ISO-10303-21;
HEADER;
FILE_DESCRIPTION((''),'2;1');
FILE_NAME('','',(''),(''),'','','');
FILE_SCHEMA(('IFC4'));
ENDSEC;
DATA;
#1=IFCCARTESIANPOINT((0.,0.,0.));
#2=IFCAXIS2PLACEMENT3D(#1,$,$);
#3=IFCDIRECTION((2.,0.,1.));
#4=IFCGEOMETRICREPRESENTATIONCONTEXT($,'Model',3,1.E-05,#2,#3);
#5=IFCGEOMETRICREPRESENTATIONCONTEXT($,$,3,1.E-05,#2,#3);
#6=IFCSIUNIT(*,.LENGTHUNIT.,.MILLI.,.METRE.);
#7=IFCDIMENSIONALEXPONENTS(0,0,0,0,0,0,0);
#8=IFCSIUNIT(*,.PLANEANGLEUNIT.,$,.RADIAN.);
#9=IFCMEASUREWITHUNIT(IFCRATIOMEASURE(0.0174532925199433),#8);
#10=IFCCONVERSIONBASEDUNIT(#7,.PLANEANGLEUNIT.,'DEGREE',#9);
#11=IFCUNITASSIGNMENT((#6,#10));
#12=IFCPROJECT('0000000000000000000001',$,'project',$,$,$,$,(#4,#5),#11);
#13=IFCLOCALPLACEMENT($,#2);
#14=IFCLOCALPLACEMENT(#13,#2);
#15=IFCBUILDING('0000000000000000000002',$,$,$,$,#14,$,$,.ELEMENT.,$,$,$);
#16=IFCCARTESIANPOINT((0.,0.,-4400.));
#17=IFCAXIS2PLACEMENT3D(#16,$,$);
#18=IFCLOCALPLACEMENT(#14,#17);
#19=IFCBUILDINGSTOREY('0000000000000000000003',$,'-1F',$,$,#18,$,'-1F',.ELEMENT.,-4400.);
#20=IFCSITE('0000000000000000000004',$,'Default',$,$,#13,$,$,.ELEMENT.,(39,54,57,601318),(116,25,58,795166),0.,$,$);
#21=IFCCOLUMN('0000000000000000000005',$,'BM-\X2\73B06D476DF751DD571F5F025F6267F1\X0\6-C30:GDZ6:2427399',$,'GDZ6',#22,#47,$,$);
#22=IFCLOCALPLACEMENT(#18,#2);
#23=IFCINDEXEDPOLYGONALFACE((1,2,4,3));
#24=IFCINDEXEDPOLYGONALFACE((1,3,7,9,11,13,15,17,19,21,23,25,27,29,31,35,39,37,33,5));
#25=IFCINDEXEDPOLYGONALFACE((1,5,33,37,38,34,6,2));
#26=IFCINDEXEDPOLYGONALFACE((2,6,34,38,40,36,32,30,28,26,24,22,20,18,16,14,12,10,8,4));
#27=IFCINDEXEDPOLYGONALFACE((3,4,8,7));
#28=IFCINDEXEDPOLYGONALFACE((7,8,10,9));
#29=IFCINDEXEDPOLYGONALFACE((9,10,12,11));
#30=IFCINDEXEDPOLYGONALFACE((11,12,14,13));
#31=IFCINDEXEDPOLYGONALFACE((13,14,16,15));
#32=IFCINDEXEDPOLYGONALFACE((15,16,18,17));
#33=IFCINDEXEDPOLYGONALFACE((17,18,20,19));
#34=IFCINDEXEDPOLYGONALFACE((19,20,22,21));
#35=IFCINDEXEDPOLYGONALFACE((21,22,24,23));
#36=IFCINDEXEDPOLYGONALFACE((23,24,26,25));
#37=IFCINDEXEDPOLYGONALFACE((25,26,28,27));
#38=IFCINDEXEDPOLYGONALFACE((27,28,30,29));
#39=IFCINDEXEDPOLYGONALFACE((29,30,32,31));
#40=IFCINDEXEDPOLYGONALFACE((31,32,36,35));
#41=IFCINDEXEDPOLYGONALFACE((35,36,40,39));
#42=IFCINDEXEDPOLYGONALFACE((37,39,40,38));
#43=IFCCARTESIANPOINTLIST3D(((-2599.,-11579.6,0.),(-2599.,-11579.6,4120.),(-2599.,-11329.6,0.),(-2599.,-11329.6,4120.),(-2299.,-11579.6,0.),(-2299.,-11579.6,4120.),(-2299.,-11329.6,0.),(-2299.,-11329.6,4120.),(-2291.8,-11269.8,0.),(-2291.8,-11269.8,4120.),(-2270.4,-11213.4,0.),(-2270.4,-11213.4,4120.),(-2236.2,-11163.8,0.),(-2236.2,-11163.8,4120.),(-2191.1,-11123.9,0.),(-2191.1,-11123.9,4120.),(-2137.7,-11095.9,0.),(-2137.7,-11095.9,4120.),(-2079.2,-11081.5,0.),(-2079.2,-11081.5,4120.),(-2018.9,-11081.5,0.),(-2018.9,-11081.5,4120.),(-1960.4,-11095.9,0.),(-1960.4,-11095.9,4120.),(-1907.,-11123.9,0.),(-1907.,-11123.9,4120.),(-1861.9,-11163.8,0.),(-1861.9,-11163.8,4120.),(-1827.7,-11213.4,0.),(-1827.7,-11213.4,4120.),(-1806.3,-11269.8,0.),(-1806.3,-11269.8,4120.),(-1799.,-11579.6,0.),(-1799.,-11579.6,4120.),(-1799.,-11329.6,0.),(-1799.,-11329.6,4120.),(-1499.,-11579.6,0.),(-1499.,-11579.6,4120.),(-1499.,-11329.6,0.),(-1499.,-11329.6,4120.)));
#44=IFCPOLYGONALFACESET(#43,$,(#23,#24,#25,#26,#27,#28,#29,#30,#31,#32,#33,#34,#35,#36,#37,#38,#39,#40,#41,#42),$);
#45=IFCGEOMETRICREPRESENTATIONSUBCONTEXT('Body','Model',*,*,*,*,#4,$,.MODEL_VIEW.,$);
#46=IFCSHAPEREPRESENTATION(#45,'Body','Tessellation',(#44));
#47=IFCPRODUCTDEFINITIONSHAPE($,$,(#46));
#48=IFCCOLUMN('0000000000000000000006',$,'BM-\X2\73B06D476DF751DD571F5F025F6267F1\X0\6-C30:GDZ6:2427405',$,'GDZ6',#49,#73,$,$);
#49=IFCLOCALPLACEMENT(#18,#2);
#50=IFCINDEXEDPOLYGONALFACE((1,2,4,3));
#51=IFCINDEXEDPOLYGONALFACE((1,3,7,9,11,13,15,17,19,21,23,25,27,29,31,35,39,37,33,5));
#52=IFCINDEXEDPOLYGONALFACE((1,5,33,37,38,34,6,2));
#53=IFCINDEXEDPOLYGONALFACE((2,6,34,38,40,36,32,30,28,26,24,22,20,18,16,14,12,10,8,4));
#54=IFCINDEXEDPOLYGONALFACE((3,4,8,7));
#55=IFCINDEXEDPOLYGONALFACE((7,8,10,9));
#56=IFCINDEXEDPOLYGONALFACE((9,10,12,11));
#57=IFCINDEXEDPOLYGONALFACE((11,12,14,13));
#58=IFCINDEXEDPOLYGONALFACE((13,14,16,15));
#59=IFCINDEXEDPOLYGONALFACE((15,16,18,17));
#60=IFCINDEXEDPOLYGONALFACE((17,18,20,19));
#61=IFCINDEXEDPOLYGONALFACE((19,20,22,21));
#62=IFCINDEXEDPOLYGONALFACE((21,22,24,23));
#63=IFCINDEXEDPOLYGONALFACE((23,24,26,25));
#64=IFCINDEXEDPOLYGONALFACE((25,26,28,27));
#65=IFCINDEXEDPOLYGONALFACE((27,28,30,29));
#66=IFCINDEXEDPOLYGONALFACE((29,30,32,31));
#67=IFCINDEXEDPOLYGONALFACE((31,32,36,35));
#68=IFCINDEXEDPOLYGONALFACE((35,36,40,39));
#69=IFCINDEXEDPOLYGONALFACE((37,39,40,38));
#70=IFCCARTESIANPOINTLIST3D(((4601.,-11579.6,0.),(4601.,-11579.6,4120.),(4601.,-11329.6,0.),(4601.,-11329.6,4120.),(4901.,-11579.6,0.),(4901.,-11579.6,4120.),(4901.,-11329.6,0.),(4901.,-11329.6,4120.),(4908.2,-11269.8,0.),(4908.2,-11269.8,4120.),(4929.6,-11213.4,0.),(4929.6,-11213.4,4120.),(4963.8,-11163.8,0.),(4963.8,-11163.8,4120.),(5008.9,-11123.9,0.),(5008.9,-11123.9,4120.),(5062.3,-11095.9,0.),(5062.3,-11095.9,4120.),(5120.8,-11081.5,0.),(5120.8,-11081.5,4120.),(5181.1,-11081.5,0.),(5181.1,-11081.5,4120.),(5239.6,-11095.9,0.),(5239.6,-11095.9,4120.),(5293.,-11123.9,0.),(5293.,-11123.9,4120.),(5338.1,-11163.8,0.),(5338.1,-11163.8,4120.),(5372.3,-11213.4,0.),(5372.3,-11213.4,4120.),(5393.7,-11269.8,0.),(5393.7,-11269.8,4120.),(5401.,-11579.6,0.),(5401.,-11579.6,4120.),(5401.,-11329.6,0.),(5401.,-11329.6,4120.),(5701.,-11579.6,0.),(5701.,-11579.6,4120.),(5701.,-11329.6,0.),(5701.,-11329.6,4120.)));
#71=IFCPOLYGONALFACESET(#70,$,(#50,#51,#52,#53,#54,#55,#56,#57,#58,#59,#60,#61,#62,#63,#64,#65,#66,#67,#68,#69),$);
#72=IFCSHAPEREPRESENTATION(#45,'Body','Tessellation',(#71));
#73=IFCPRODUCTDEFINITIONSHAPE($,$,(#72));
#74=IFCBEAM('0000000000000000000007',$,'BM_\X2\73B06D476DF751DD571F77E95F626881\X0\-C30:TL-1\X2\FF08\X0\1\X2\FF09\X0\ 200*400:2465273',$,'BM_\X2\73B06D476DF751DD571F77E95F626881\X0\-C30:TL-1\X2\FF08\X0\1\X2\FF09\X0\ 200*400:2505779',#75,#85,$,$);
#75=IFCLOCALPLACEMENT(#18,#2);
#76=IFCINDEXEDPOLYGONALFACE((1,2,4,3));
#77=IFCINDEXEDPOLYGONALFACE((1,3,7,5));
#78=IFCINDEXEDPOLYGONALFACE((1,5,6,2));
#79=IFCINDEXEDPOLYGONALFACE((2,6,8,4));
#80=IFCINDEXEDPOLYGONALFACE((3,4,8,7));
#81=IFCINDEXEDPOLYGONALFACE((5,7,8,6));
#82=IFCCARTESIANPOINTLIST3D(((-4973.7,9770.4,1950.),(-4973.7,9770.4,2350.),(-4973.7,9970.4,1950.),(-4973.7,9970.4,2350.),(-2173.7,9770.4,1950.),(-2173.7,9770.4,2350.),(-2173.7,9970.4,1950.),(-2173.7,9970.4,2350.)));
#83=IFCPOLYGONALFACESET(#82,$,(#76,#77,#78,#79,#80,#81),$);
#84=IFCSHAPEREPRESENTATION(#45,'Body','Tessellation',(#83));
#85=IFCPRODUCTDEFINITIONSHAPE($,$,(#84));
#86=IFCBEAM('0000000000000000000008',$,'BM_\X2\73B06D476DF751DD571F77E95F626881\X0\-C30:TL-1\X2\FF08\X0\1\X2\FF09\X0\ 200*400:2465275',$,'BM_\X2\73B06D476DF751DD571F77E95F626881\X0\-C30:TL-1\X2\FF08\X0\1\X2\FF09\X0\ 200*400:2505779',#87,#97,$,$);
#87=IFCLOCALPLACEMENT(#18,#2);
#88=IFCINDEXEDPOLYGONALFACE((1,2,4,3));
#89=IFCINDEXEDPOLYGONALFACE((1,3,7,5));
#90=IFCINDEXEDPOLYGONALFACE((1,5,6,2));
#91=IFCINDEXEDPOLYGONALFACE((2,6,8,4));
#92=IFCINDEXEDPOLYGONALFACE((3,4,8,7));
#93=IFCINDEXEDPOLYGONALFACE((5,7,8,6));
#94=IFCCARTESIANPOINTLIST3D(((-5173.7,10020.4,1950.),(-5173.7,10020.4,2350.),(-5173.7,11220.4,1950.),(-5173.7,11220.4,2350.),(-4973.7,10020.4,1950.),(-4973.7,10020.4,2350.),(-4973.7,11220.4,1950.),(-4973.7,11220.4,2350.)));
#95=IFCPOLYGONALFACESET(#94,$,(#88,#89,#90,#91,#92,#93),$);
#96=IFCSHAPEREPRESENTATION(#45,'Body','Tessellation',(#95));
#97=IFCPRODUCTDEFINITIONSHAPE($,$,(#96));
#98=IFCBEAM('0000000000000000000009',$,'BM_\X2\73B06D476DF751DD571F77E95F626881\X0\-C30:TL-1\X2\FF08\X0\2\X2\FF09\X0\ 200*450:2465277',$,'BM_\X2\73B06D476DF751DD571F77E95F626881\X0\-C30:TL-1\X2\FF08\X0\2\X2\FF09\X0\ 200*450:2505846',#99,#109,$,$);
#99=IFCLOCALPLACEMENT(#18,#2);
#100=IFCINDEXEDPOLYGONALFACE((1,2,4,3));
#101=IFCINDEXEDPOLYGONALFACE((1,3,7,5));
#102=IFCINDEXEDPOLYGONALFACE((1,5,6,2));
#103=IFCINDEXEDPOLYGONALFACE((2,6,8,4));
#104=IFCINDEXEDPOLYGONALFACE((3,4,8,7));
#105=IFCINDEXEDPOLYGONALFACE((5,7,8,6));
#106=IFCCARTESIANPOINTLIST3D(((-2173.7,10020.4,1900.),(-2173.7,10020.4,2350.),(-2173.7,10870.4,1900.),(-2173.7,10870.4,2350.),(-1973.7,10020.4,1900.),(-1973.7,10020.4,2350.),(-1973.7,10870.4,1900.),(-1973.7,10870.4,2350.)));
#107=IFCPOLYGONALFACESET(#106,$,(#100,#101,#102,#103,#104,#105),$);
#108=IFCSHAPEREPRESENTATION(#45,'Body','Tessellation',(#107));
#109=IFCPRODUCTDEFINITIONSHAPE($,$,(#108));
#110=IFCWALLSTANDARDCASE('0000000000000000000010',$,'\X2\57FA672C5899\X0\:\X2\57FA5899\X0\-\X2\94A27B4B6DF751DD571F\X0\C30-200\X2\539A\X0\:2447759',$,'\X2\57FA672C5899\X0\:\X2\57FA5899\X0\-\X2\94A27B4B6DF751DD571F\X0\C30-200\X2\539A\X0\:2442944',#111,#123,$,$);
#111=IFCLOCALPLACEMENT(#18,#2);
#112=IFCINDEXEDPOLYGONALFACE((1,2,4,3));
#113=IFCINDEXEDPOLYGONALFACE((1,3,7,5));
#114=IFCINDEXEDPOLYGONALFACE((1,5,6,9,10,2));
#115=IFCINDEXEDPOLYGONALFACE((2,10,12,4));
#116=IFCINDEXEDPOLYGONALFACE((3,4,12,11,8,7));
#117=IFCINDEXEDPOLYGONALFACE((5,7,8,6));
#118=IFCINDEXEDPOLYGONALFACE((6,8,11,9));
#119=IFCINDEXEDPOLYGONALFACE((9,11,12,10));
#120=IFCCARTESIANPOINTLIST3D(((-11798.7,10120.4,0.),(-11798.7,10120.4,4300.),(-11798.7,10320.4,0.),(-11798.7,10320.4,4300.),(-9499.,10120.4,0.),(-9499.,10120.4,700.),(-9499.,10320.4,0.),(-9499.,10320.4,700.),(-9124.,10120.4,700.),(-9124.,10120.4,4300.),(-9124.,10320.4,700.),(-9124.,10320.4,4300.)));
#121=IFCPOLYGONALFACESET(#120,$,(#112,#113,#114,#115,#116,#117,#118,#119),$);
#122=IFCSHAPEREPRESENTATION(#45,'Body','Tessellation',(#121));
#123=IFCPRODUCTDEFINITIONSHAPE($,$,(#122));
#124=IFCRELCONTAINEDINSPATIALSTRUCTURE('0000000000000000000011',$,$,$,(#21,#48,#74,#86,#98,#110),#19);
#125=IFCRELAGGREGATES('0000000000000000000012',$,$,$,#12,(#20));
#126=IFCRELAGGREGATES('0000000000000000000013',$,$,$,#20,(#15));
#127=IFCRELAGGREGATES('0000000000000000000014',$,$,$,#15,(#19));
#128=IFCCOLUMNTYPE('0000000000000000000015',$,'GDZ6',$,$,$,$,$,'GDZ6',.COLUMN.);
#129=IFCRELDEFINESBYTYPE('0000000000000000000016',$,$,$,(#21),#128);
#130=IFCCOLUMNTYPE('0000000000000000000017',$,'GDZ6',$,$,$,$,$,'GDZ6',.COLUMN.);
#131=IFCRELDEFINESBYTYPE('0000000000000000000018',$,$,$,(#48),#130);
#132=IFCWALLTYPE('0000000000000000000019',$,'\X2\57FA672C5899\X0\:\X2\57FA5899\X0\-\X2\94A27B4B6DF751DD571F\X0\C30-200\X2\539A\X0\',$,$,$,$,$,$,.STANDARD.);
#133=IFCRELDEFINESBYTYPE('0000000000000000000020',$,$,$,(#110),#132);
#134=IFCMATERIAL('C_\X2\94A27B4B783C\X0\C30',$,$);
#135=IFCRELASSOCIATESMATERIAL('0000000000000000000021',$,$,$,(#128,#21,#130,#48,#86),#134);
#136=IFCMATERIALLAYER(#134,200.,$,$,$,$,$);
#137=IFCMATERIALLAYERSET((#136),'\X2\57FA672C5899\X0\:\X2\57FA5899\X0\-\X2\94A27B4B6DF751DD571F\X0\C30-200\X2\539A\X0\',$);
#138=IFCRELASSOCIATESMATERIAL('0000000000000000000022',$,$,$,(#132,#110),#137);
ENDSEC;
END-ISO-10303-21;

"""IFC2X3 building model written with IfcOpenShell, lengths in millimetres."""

from ifc_helpers import new_model, entity, si_unit, converted_unit, direction, frame, frame_2d, origin, place, context, subcontext, project, spatial, polyline, circle_curve, parameter, trimmed, segment, composite_curve, rectangle, outline, extrude, clip, bounded_halfspace, source, transform, mapped, material, layer, layer_set, layer_usage, type_object, type_shapes, element, save


model = new_model("IFC2X3")

# Units and contexts
model_context = context("Model", 3, precision=1e-05, world=origin(), true_north=direction((2.0, 0.0, 1.0)))
context_of_model = context(None, 3, precision=1e-05, world=origin(), true_north=direction((2.0, 0.0, 1.0)))
body_context = subcontext(model_context, "Body", "Model", "MODEL_VIEW")
ifc_project = project(units=[si_unit("LENGTHUNIT", "METRE", prefix="MILLI"), converted_unit("PLANEANGLEUNIT", "DEGREE", entity("IfcRatioMeasure", 0.0174532925199433), si_unit("PLANEANGLEUNIT", "RADIAN"), dimensions=[0, 0, 0, 0, 0, 0, 0])], contexts=[model_context, context_of_model])

# Site, building, storey
site_placement = place(None, origin())
site = spatial("IfcSite", under=ifc_project, at=site_placement, Name="Default", CompositionType="ELEMENT", RefLatitude=(39, 54, 57, 601318), RefLongitude=(116, 25, 58, 795166), RefElevation=0.0)
building_placement = place(site_placement, origin())
building = spatial("IfcBuilding", under=site, at=building_placement, CompositionType="ELEMENT")
storey_placement = place(building_placement, frame((0.0, 0.0, -4400.0)))
storey = spatial("IfcBuildingStorey", under=building, at=storey_placement, Name="-1F", LongName="-1F", CompositionType="ELEMENT", Elevation=-4400.0)

# Columns
ifc_material_1 = material(Name="C_钢筋砼C30")
column_type_1 = type_object("IfcColumnType", Name="GDZ6", ElementType="GDZ6", PredefinedType="COLUMN", material=ifc_material_1)
shared_shape_1 = source(origin(), body_context, "Body", "SweptSolid", [
    extrude(outline(composite_curve([segment(polyline([(-125.0, -550.0), (125.0, -550.0)]), True, "CONTINUOUS"), segment(polyline([(125.0, -550.0), (125.0, -250.0)]), True, "CONTINUOUS"), segment(trimmed(circle_curve(frame_2d((125.0, 0.0), x_axis=(0.0, -1.0)), 250.0), [parameter(0.0)], [parameter(180.0)], True, "PARAMETER"), True, "CONTINUOUS"), segment(polyline([(125.0, 250.0), (125.0, 550.0)]), True, "CONTINUOUS"), segment(polyline([(125.0, 550.0), (-125.0, 550.0)]), True, "CONTINUOUS"), segment(polyline([(-125.0, 550.0), (-125.0, 250.0)]), True, "CONTINUOUS"), segment(polyline([(-125.0, 250.0), (-125.0, -250.0)]), True, "CONTINUOUS"), segment(polyline([(-125.0, -250.0), (-125.0, -550.0)]), True, "CONTINUOUS")], self_intersect=False)), frame((-2049.0, -11454.6, -4400.0), z_axis=(0.0, 0.0, 1.0), x_axis=(0.0, 1.0, 0.0)), (0.0, 0.0, 1.0), 4120.0),
])
type_shapes(column_type_1, [shared_shape_1])
column_1_placement = place(storey_placement, frame((0.0, 0.0, 4400.0)))
element("IfcColumn", 1, at=column_1_placement, inside=storey, type_object=column_type_1, material=ifc_material_1, Name="BM-现浇混凝土异形柱6-C30:GDZ6:2427399", ObjectType="GDZ6", context=body_context, shape_type="MappedRepresentation", body=[
    mapped(shared_shape_1, transform((0.0, 0.0, 0.0), scale=1.0)),
])
column_type_2 = type_object("IfcColumnType", Name="GDZ6", ElementType="GDZ6", PredefinedType="COLUMN", material=ifc_material_1)
shared_shape_2 = source(origin(), body_context, "Body", "SweptSolid", [
    extrude(outline(composite_curve([segment(polyline([(-125.0, -550.0), (125.0, -550.0)]), True, "CONTINUOUS"), segment(polyline([(125.0, -550.0), (125.0, -250.0)]), True, "CONTINUOUS"), segment(trimmed(circle_curve(frame_2d((125.0, 0.0), x_axis=(0.0, 1.0)), 250.0), [parameter(180.0)], [parameter(0.0)], True, "PARAMETER"), True, "CONTINUOUS"), segment(polyline([(125.0, 250.0), (125.0, 550.0)]), True, "CONTINUOUS"), segment(polyline([(125.0, 550.0), (-125.0, 550.0)]), True, "CONTINUOUS"), segment(polyline([(-125.0, 550.0), (-125.0, 250.0)]), True, "CONTINUOUS"), segment(polyline([(-125.0, 250.0), (-125.0, -250.0)]), True, "CONTINUOUS"), segment(polyline([(-125.0, -250.0), (-125.0, -550.0)]), True, "CONTINUOUS")], self_intersect=False)), frame((5151.0, -11454.6, -4400.0), z_axis=(0.0, 0.0, 1.0), x_axis=(0.0, 1.0, 0.0)), (0.0, 0.0, 1.0), 4120.0),
])
type_shapes(column_type_2, [shared_shape_2])
column_2_placement = place(storey_placement, frame((0.0, 0.0, 4400.0)))
element("IfcColumn", 2, at=column_2_placement, inside=storey, type_object=column_type_2, material=ifc_material_1, Name="BM-现浇混凝土异形柱6-C30:GDZ6:2427405", ObjectType="GDZ6", context=body_context, shape_type="MappedRepresentation", body=[
    mapped(shared_shape_2, transform((0.0, 0.0, 0.0), scale=1.0)),
])

# Beams
beam_1_placement = place(storey_placement, frame((-5073.7, 9870.4, 2350.0)))
element("IfcBeam", 3, at=beam_1_placement, inside=storey, Name="BM_现浇混凝土矩形梁-C30:TL-1（1） 200*400:2465273", ObjectType="BM_现浇混凝土矩形梁-C30:TL-1（1） 200*400:2505779", context=body_context, shape_type="SweptSolid", body=[
    extrude(rectangle(XDim=400.0, YDim=200.0, at=frame_2d((0.0, 0.0), x_axis=(1.0, 0.0))), frame((100.0, 0.0, -200.0), z_axis=(1.0, 0.0, 0.0), x_axis=(0.0, 0.0, -1.0)), (0.0, 0.0, 1.0), 2800.0),
])
beam_2_placement = place(storey_placement, frame((-5073.7, 11345.4, 2350.0), z_axis=(0.0, 0.0, 1.0), x_axis=(0.0, -1.0, 0.0)))
element("IfcBeam", 4, at=beam_2_placement, inside=storey, material=ifc_material_1, Name="BM_现浇混凝土矩形梁-C30:TL-1（1） 200*400:2465275", ObjectType="BM_现浇混凝土矩形梁-C30:TL-1（1） 200*400:2505779", context=body_context, shape_type="SweptSolid", body=[
    extrude(rectangle(XDim=400.0, YDim=200.0, at=frame_2d((0.0, 0.0), x_axis=(1.0, 0.0))), frame((125.0, 0.0, -200.0), z_axis=(1.0, 0.0, 0.0), x_axis=(0.0, 0.0, -1.0)), (0.0, 0.0, 1.0), 1200.0),
])
beam_3_placement = place(storey_placement, frame((-2073.7, 11295.4, 2350.0), z_axis=(0.0, 0.0, 1.0), x_axis=(0.0, -1.0, 0.0)))
element("IfcBeam", 5, at=beam_3_placement, inside=storey, Name="BM_现浇混凝土矩形梁-C30:TL-1（2） 200*450:2465277", ObjectType="BM_现浇混凝土矩形梁-C30:TL-1（2） 200*450:2505846", context=body_context, shape_type="SweptSolid", body=[
    extrude(rectangle(XDim=450.0, YDim=200.0, at=frame_2d((0.0, 0.0), x_axis=(1.0, 0.0))), frame((425.0, 0.0, -225.0), z_axis=(1.0, 0.0, 0.0), x_axis=(0.0, 0.0, -1.0)), (0.0, 0.0, 1.0), 850.0),
])

# Wall
ifc_layer_1 = layer(ifc_material_1, 200.0)
ifc_layer_set_1 = layer_set([ifc_layer_1], Name="基本墙:基墙-钢筋混凝土C30-200厚")
ifc_layer_usage = layer_usage(ifc_layer_set_1, "AXIS2", "POSITIVE", -100.0)
wall_type_1 = type_object("IfcWallType", Name="基本墙:基墙-钢筋混凝土C30-200厚", PredefinedType="STANDARD", material=ifc_layer_set_1)
wall_1_placement = place(storey_placement, frame((-9124.0, 10220.4, 0.0), z_axis=(0.0, 0.0, 1.0), x_axis=(-1.0, 0.0, 0.0)))
element("IfcWallStandardCase", 6, at=wall_1_placement, inside=storey, type_object=wall_type_1, material=ifc_layer_usage, Name="基本墙:基墙-钢筋混凝土C30-200厚:2447759", ObjectType="基本墙:基墙-钢筋混凝土C30-200厚:2442944", context=body_context, shape_type="Clipping", body=[
    clip(clip(extrude(rectangle(XDim=2674.6, YDim=200.0, at=frame_2d((1337.3, 0.0), x_axis=(-1.0, 0.0))), origin(), (0.0, 0.0, 1.0), 4300.0), bounded_halfspace(frame((375.0, 100.0, 700.0), z_axis=(0.0, 0.0, 1.0), x_axis=(0.0, -1.0, 0.0)), True, frame((375.0, 100.0, 700.0), z_axis=(0.0, 0.0, 1.0), x_axis=(0.0, -1.0, 0.0)), polyline([(0.0, 0.0), (0.0, -125.0), (0.0, -375.0), (200.0, -375.0), (200.0, 0.0), (0.0, 0.0)]))), bounded_halfspace(frame((375.0, -100.0, 700.0), z_axis=(1.0, 0.0, 0.0), x_axis=(0.0, -1.0, 0.0)), True, frame((375.0, -100.0, 700.0), z_axis=(1.0, 0.0, 0.0), x_axis=(0.0, -1.0, 0.0)), polyline([(0.0, 0.0), (0.0, 700.0), (-200.0, 700.0), (-200.0, 0.0), (0.0, 0.0)]))),
])

save(model, "model.ifc")
